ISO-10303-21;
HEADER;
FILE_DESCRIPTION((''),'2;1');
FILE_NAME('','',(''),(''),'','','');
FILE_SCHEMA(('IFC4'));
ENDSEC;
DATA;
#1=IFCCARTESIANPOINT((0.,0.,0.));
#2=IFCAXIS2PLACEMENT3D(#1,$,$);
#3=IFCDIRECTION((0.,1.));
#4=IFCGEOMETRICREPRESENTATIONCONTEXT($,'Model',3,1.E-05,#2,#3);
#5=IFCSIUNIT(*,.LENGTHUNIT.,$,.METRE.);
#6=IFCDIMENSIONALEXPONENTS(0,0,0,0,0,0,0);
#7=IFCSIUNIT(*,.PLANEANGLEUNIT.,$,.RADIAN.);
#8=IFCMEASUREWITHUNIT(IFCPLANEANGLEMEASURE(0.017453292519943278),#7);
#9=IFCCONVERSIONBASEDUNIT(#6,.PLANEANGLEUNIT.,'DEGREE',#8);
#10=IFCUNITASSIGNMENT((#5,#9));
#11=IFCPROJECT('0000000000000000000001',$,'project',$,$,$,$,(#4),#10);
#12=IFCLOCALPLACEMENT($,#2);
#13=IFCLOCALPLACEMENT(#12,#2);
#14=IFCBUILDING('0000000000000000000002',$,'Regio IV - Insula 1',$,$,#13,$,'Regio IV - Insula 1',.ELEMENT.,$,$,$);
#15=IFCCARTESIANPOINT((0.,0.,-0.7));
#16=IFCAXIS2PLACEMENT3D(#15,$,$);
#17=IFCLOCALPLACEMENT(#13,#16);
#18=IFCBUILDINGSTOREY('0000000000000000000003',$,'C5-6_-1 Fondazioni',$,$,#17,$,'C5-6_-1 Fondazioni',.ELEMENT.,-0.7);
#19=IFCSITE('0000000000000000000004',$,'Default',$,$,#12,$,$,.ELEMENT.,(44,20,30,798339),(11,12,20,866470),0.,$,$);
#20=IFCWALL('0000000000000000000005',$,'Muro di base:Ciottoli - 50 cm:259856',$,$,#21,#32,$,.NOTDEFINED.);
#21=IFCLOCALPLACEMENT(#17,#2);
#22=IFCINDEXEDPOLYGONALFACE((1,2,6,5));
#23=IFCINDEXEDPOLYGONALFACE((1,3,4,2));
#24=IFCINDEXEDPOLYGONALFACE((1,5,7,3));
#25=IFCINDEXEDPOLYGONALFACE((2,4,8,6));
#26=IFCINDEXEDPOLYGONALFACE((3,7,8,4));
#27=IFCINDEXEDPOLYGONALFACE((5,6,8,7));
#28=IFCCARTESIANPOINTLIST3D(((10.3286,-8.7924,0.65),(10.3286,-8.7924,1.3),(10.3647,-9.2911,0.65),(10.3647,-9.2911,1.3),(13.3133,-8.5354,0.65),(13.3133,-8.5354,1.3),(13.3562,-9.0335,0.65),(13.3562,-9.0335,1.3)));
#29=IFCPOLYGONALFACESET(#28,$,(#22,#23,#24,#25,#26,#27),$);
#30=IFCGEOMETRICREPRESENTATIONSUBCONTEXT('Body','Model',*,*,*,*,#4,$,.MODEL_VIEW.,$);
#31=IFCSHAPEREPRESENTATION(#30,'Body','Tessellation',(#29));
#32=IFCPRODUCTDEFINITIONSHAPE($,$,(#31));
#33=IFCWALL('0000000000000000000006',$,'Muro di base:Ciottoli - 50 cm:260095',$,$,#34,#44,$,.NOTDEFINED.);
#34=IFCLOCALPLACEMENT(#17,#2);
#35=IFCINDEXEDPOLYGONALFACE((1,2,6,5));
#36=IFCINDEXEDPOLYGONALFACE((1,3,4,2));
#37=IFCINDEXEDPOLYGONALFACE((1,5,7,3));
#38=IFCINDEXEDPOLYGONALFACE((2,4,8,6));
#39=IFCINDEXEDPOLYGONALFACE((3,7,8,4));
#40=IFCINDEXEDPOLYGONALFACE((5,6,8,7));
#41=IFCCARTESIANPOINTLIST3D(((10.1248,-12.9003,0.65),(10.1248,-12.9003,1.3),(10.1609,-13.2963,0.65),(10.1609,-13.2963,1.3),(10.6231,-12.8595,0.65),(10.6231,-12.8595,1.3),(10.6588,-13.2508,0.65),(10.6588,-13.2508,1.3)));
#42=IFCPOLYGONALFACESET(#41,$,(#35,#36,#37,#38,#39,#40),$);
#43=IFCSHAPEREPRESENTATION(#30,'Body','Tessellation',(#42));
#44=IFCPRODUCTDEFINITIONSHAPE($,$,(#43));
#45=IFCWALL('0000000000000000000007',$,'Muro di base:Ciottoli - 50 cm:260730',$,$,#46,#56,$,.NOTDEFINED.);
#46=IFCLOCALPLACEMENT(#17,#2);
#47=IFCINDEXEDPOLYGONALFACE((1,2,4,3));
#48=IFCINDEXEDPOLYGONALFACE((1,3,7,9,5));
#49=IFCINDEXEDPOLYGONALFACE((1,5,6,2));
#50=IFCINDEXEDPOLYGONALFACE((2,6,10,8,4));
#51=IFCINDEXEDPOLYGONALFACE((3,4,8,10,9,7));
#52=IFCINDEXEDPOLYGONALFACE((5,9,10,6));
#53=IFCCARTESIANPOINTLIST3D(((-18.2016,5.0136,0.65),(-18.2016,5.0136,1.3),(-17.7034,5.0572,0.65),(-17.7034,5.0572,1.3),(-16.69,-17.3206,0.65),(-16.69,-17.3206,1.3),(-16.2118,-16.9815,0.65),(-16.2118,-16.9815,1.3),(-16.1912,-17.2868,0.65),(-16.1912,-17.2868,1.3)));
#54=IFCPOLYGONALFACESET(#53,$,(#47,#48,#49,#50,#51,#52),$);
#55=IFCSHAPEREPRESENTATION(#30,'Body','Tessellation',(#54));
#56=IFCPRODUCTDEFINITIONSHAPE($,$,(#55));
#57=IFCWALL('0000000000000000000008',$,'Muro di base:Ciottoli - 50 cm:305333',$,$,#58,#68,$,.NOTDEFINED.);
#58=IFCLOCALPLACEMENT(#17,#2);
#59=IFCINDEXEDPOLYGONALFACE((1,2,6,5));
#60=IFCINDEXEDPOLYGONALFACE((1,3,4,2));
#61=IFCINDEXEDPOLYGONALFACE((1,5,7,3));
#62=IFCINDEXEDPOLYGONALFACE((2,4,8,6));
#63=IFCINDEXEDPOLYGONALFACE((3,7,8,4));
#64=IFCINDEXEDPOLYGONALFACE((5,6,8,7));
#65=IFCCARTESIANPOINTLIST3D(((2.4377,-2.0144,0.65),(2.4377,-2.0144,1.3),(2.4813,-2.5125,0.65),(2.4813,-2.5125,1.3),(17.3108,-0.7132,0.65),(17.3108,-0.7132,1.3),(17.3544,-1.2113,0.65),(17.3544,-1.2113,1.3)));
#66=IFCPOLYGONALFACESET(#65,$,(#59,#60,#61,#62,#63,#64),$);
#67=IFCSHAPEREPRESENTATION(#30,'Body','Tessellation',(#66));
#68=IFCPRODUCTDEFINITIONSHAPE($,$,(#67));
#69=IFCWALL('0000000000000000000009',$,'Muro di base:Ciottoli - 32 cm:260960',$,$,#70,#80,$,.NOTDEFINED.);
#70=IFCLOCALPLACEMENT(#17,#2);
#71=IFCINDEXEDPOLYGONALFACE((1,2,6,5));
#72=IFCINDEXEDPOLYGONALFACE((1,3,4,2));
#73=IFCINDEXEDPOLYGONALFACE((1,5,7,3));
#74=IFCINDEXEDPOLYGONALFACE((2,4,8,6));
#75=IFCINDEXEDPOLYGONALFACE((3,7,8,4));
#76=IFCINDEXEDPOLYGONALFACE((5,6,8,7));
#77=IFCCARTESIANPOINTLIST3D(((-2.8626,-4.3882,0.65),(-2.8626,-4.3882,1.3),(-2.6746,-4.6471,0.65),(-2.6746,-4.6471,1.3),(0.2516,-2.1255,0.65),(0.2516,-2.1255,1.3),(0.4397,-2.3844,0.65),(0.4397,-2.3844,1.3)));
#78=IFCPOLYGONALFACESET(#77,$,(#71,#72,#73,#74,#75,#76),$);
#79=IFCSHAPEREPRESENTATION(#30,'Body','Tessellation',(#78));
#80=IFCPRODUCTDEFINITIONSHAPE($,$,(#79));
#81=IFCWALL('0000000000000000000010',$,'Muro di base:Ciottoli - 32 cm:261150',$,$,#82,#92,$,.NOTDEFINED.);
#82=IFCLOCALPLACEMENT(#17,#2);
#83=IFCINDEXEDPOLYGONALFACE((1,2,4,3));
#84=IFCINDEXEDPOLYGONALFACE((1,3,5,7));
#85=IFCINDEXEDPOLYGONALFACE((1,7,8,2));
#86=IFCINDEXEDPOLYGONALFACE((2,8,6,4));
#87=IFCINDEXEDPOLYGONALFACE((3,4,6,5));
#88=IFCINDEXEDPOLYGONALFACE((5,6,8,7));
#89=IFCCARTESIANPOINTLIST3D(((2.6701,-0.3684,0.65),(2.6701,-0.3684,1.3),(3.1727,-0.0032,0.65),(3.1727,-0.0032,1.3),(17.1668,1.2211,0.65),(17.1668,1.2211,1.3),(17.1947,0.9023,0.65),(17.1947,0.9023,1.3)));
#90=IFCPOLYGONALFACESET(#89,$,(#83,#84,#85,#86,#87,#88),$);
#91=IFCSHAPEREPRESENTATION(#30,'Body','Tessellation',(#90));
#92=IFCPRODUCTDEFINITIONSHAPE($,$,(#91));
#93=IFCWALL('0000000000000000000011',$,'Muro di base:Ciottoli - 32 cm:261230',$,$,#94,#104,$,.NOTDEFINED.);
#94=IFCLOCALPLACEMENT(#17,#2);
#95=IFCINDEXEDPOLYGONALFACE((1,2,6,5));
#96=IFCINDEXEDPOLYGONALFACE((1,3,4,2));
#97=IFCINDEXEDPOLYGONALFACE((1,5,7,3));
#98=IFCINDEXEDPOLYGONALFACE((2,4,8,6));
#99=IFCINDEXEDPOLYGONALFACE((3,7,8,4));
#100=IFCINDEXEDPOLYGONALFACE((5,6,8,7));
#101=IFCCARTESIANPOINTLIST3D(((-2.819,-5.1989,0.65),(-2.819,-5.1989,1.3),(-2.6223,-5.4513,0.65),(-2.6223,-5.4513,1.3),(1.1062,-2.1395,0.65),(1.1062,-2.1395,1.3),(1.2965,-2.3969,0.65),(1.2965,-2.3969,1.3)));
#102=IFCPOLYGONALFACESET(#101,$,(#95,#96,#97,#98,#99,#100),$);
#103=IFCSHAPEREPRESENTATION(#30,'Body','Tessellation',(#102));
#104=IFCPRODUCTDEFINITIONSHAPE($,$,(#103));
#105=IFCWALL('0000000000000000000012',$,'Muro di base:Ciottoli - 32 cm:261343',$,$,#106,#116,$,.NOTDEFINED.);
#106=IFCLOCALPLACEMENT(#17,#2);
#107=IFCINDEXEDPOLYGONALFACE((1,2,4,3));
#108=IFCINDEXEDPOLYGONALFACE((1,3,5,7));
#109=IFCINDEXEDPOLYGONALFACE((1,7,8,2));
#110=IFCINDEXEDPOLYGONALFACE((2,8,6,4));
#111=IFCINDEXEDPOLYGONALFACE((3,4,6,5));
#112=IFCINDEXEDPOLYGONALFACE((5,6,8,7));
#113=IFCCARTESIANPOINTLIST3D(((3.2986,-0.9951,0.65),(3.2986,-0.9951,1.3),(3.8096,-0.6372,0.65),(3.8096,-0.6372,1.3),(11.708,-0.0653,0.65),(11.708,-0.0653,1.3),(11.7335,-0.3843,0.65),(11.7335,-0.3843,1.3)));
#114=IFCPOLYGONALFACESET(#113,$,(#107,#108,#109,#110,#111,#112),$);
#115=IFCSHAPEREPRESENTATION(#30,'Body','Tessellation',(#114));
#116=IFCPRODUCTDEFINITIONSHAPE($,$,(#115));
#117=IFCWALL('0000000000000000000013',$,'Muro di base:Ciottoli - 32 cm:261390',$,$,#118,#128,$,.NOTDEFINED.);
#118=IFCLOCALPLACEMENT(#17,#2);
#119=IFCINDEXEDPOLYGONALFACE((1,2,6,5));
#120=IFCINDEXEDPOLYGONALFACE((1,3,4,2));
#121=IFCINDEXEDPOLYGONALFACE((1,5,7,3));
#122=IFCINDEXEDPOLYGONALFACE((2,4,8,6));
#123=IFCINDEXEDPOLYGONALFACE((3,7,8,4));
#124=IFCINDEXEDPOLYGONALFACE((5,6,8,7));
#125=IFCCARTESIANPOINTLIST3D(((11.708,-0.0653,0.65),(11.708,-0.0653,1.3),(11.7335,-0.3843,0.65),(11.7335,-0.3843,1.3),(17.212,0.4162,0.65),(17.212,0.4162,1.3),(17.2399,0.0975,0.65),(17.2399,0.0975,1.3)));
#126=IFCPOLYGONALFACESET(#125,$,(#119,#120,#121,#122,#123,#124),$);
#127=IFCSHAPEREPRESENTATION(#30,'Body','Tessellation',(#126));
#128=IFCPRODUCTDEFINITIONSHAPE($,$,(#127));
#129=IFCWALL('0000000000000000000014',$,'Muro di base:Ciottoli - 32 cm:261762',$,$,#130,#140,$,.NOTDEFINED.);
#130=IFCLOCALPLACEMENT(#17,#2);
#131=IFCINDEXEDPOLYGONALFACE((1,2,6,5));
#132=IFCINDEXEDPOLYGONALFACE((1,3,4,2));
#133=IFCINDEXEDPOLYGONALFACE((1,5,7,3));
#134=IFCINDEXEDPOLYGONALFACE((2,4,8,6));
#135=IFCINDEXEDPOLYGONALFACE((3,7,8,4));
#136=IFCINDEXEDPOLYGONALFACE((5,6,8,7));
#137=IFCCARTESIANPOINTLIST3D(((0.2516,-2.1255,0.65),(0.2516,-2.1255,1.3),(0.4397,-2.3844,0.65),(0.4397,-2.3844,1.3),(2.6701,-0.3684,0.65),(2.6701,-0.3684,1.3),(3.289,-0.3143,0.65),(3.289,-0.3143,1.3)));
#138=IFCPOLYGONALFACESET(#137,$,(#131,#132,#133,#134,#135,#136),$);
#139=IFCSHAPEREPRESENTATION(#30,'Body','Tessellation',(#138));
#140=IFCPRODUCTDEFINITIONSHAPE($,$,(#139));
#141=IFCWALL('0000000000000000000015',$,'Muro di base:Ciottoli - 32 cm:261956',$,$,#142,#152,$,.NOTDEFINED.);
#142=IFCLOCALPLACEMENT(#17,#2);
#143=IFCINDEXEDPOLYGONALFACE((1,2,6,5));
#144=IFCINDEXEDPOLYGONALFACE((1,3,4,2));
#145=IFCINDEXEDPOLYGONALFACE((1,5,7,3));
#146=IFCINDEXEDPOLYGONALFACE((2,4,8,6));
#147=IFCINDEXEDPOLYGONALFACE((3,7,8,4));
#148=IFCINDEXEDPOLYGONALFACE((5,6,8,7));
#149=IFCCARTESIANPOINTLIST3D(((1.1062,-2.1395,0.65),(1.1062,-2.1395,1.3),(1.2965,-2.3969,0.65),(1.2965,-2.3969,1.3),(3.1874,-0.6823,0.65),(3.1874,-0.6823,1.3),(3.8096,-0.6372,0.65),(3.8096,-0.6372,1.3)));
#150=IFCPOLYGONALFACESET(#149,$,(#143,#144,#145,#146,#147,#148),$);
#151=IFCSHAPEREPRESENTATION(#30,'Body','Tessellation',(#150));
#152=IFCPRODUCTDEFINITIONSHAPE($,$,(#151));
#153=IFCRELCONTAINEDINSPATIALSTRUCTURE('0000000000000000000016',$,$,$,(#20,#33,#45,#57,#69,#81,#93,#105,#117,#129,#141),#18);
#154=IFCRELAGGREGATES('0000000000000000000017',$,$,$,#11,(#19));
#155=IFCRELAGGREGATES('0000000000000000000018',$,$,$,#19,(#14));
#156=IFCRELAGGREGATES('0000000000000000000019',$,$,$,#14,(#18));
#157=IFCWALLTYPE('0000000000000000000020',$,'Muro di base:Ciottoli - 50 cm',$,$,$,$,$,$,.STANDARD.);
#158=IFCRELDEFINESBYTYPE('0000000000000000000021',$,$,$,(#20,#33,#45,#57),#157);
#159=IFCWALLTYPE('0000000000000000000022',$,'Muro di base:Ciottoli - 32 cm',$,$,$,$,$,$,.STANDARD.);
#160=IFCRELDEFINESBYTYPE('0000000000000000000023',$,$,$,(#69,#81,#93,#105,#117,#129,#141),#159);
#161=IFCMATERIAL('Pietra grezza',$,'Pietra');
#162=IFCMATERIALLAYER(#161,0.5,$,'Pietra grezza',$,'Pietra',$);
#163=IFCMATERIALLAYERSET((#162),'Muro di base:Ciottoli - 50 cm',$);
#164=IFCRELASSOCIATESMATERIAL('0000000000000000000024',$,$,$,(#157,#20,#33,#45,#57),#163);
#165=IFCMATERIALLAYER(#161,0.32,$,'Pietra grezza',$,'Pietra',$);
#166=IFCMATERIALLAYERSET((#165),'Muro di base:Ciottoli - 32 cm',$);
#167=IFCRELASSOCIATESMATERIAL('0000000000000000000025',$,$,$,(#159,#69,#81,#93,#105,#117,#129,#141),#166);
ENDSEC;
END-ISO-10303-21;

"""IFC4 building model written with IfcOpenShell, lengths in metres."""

from ifc_helpers import new_model, entity, si_unit, converted_unit, direction, frame, frame_2d, origin, place, context, subcontext, project, spatial, polyline, rectangle, outline, extrude, material, layer, layer_set, layer_usage, type_object, element, save


model = new_model("IFC4")

# Units and contexts
model_context = context("Model", 3, precision=1e-05, world=origin(), true_north=direction((0.0, 1.0)))
body_context = subcontext(model_context, "Body", "Model", "MODEL_VIEW")
ifc_project = project(units=[si_unit("LENGTHUNIT", "METRE"), converted_unit("PLANEANGLEUNIT", "DEGREE", entity("IfcPlaneAngleMeasure", 0.017453292519943278), si_unit("PLANEANGLEUNIT", "RADIAN"), dimensions=[0, 0, 0, 0, 0, 0, 0])], contexts=[model_context])

# Site, building, storey
site_placement = place(None, origin())
site = spatial("IfcSite", under=ifc_project, at=site_placement, Name="Default", CompositionType="ELEMENT", RefLatitude=(44, 20, 30, 798339), RefLongitude=(11, 12, 20, 866470), RefElevation=0.0)
building_placement = place(site_placement, origin())
building = spatial("IfcBuilding", under=site, at=building_placement, Name="Regio IV - Insula 1", LongName="Regio IV - Insula 1", CompositionType="ELEMENT")
storey_placement = place(building_placement, frame((0.0, 0.0, -0.7)))
storey = spatial("IfcBuildingStorey", under=building, at=storey_placement, Name="C5-6_-1 Fondazioni", LongName="C5-6_-1 Fondazioni", CompositionType="ELEMENT", Elevation=-0.7)

# Walls
ifc_material = material(Name="Pietra grezza", Category="Pietra")
ifc_layer_1 = layer(ifc_material, 0.5, Name="Pietra grezza", Category="Pietra")
ifc_layer_set_1 = layer_set([ifc_layer_1], Name="Muro di base:Ciottoli - 50 cm")
wall_type_1 = type_object("IfcWallType", Name="Muro di base:Ciottoli - 50 cm", PredefinedType="STANDARD", material=ifc_layer_set_1)
ifc_layer_usage_1 = layer_usage(ifc_layer_set_1, "AXIS2", "NEGATIVE", 0.25)
wall_1_placement = place(storey_placement, frame((13.3348, -8.7844, 0.65), z_axis=(0.0, 0.0, 1.0), x_axis=(-0.996312, -0.085801, 0.0)))
element("IfcWall", 1, at=wall_1_placement, inside=storey, type_object=wall_type_1, material=ifc_layer_usage_1, Name="Muro di base:Ciottoli - 50 cm:259856", PredefinedType="NOTDEFINED", context=body_context, shape_type="SweptSolid", body=[
    extrude(outline(polyline([(2.9957, -0.25), (3.0026, 0.25), (0.0, 0.25), (0.0, -0.25), (2.9957, -0.25)])), origin(), (0.0, 0.0, 1.0), 0.65),
])
ifc_layer_usage_2 = layer_usage(ifc_layer_set_1, "AXIS2", "NEGATIVE", 0.25)
wall_2_placement = place(storey_placement, frame((10.3737, -12.8776, 0.65), z_axis=(0.0, 0.0, 1.0), x_axis=(0.09094, -0.995856, 0.0)))
element("IfcWall", 2, at=wall_2_placement, inside=storey, type_object=wall_type_1, material=ifc_layer_usage_2, Name="Muro di base:Ciottoli - 50 cm:260095", PredefinedType="NOTDEFINED", context=body_context, shape_type="SweptSolid", body=[
    extrude(outline(polyline([(0.3976, -0.25), (0.3976, 0.25), (0.0047, 0.25), (0.0, -0.25), (0.3976, -0.25)])), origin(), (0.0, 0.0, 1.0), 0.65),
])
ifc_layer_usage_3 = layer_usage(ifc_layer_set_1, "AXIS2", "NEGATIVE", 0.25)
wall_3_placement = place(storey_placement, frame((-17.9528, 5.0403, 0.65), z_axis=(0.0, 0.0, 1.0), x_axis=(0.067526, -0.997718, 0.0)))
element("IfcWall", 3, at=wall_3_placement, inside=storey, type_object=wall_type_1, material=ifc_layer_usage_3, Name="Muro di base:Ciottoli - 50 cm:260730", PredefinedType="NOTDEFINED", context=body_context, shape_type="SweptSolid", body=[
    extrude(outline(polyline([(22.3951, -0.25), (22.3951, 0.25), (22.0892, 0.25), (0.0, 0.25), (0.0098, -0.25), (22.3951, -0.25)])), origin(), (0.0, 0.0, 1.0), 0.65),
])
ifc_layer_usage_4 = layer_usage(ifc_layer_set_1, "AXIS2", "NEGATIVE", 0.25)
wall_4_placement = place(storey_placement, frame((2.4595, -2.2635, 0.65), z_axis=(0.0, 0.0, 1.0), x_axis=(0.996195, 0.087156, 0.0)))
element("IfcWall", 4, at=wall_4_placement, inside=storey, type_object=wall_type_1, material=ifc_layer_usage_4, Name="Muro di base:Ciottoli - 50 cm:305333", PredefinedType="NOTDEFINED", context=body_context, shape_type="SweptSolid", body=[
    extrude(rectangle(XDim=14.93, YDim=0.5, at=frame_2d((7.465, 0.0), x_axis=(-1.0, 0.0))), origin(), (0.0, 0.0, 1.0), 0.65),
])
ifc_layer_2 = layer(ifc_material, 0.32, Name="Pietra grezza", Category="Pietra")
ifc_layer_set_2 = layer_set([ifc_layer_2], Name="Muro di base:Ciottoli - 32 cm")
ifc_layer_usage_5 = layer_usage(ifc_layer_set_2, "AXIS2", "NEGATIVE", 0.16)
wall_type_2 = type_object("IfcWallType", Name="Muro di base:Ciottoli - 32 cm", PredefinedType="STANDARD", material=ifc_layer_set_2)
wall_5_placement = place(storey_placement, frame((-2.7686, -4.5176, 0.65), z_axis=(0.0, 0.0, 1.0), x_axis=(0.809017, 0.587785, 0.0)))
element("IfcWall", 5, at=wall_5_placement, inside=storey, type_object=wall_type_2, material=ifc_layer_usage_5, Name="Muro di base:Ciottoli - 32 cm:260960", PredefinedType="NOTDEFINED", context=body_context, shape_type="SweptSolid", body=[
    extrude(rectangle(XDim=3.8494, YDim=0.32, at=frame_2d((1.9247, 0.0), x_axis=(-1.0, 0.0))), origin(), (0.0, 0.0, 1.0), 0.65),
])
ifc_layer_usage_6 = layer_usage(ifc_layer_set_2, "AXIS2", "NEGATIVE", 0.16)
wall_6_placement = place(storey_placement, frame((2.6561, -0.2091, 0.65), z_axis=(0.0, 0.0, 1.0), x_axis=(0.996195, 0.087156, 0.0)))
element("IfcWall", 6, at=wall_6_placement, inside=storey, type_object=wall_type_2, material=ifc_layer_usage_6, Name="Muro di base:Ciottoli - 32 cm:261150", PredefinedType="NOTDEFINED", context=body_context, shape_type="SweptSolid", body=[
    extrude(outline(polyline([(14.5801, -0.16), (14.5801, 0.16), (0.5326, 0.16), (0.0, -0.16), (14.5801, -0.16)])), origin(), (0.0, 0.0, 1.0), 0.65),
])
ifc_layer_usage_7 = layer_usage(ifc_layer_set_2, "AXIS2", "NEGATIVE", 0.16)
wall_7_placement = place(storey_placement, frame((-2.7206, -5.3251, 0.65), z_axis=(0.0, 0.0, 1.0), x_axis=(0.78872, 0.614752, 0.0)))
element("IfcWall", 7, at=wall_7_placement, inside=storey, type_object=wall_type_2, material=ifc_layer_usage_7, Name="Muro di base:Ciottoli - 32 cm:261230", PredefinedType="NOTDEFINED", context=body_context, shape_type="SweptSolid", body=[
    extrude(outline(polyline([(4.9685, -0.16), (4.9767, 0.16), (0.0, 0.16), (0.0, -0.16), (4.9685, -0.16)])), origin(), (0.0, 0.0, 1.0), 0.65),
])
ifc_layer_usage_8 = layer_usage(ifc_layer_set_2, "AXIS2", "NEGATIVE", 0.16)
wall_8_placement = place(storey_placement, frame((3.287, -0.8355, 0.65), z_axis=(0.0, 0.0, 1.0), x_axis=(0.997389, 0.07222, 0.0)))
element("IfcWall", 8, at=wall_8_placement, inside=storey, type_object=wall_type_2, material=ifc_layer_usage_8, Name="Muro di base:Ciottoli - 32 cm:261343", PredefinedType="NOTDEFINED", context=body_context, shape_type="SweptSolid", body=[
    extrude(outline(polyline([(8.457, -0.16), (8.4546, 0.16), (0.5356, 0.16), (0.0, -0.16), (8.457, -0.16)])), origin(), (0.0, 0.0, 1.0), 0.65),
])
ifc_layer_usage_9 = layer_usage(ifc_layer_set_2, "AXIS2", "NEGATIVE", 0.16)
wall_9_placement = place(storey_placement, frame((11.7196, -0.2249, 0.65), z_axis=(0.0, 0.0, 1.0), x_axis=(0.996195, 0.087156, 0.0)))
element("IfcWall", 9, at=wall_9_placement, inside=storey, type_object=wall_type_2, material=ifc_layer_usage_9, Name="Muro di base:Ciottoli - 32 cm:261390", PredefinedType="NOTDEFINED", context=body_context, shape_type="SweptSolid", body=[
    extrude(outline(polyline([(5.5274, -0.16), (5.5274, 0.16), (0.0024, 0.16), (0.0, -0.16), (5.5274, -0.16)])), origin(), (0.0, 0.0, 1.0), 0.65),
])
ifc_layer_usage_10 = layer_usage(ifc_layer_set_2, "AXIS2", "NEGATIVE", 0.16)
wall_10_placement = place(storey_placement, frame((0.3457, -2.255, 0.65), z_axis=(0.0, 0.0, 1.0), x_axis=(0.809017, 0.587785, 0.0)))
element("IfcWall", 10, at=wall_10_placement, inside=storey, type_object=wall_type_2, material=ifc_layer_usage_10, Name="Muro di base:Ciottoli - 32 cm:261762", PredefinedType="NOTDEFINED", context=body_context, shape_type="SweptSolid", body=[
    extrude(outline(polyline([(3.5219, -0.16), (2.9893, 0.16), (0.0, 0.16), (0.0, -0.16), (3.5219, -0.16)])), origin(), (0.0, 0.0, 1.0), 0.65),
])
ifc_layer_usage_11 = layer_usage(ifc_layer_set_2, "AXIS2", "NEGATIVE", 0.16)
wall_11_placement = place(storey_placement, frame((1.198, -2.2706, 0.65), z_axis=(0.0, 0.0, 1.0), x_axis=(0.819152, 0.573576, 0.0)))
element("IfcWall", 11, at=wall_11_placement, inside=storey, type_object=wall_type_2, material=ifc_layer_usage_11, Name="Muro di base:Ciottoli - 32 cm:261956", PredefinedType="NOTDEFINED", context=body_context, shape_type="SweptSolid", body=[
    extrude(outline(polyline([(3.0762, -0.16), (2.5406, 0.16), (0.0, 0.16), (0.0082, -0.16), (3.0762, -0.16)])), origin(), (0.0, 0.0, 1.0), 0.65),
])

save(model, "model.ifc")
